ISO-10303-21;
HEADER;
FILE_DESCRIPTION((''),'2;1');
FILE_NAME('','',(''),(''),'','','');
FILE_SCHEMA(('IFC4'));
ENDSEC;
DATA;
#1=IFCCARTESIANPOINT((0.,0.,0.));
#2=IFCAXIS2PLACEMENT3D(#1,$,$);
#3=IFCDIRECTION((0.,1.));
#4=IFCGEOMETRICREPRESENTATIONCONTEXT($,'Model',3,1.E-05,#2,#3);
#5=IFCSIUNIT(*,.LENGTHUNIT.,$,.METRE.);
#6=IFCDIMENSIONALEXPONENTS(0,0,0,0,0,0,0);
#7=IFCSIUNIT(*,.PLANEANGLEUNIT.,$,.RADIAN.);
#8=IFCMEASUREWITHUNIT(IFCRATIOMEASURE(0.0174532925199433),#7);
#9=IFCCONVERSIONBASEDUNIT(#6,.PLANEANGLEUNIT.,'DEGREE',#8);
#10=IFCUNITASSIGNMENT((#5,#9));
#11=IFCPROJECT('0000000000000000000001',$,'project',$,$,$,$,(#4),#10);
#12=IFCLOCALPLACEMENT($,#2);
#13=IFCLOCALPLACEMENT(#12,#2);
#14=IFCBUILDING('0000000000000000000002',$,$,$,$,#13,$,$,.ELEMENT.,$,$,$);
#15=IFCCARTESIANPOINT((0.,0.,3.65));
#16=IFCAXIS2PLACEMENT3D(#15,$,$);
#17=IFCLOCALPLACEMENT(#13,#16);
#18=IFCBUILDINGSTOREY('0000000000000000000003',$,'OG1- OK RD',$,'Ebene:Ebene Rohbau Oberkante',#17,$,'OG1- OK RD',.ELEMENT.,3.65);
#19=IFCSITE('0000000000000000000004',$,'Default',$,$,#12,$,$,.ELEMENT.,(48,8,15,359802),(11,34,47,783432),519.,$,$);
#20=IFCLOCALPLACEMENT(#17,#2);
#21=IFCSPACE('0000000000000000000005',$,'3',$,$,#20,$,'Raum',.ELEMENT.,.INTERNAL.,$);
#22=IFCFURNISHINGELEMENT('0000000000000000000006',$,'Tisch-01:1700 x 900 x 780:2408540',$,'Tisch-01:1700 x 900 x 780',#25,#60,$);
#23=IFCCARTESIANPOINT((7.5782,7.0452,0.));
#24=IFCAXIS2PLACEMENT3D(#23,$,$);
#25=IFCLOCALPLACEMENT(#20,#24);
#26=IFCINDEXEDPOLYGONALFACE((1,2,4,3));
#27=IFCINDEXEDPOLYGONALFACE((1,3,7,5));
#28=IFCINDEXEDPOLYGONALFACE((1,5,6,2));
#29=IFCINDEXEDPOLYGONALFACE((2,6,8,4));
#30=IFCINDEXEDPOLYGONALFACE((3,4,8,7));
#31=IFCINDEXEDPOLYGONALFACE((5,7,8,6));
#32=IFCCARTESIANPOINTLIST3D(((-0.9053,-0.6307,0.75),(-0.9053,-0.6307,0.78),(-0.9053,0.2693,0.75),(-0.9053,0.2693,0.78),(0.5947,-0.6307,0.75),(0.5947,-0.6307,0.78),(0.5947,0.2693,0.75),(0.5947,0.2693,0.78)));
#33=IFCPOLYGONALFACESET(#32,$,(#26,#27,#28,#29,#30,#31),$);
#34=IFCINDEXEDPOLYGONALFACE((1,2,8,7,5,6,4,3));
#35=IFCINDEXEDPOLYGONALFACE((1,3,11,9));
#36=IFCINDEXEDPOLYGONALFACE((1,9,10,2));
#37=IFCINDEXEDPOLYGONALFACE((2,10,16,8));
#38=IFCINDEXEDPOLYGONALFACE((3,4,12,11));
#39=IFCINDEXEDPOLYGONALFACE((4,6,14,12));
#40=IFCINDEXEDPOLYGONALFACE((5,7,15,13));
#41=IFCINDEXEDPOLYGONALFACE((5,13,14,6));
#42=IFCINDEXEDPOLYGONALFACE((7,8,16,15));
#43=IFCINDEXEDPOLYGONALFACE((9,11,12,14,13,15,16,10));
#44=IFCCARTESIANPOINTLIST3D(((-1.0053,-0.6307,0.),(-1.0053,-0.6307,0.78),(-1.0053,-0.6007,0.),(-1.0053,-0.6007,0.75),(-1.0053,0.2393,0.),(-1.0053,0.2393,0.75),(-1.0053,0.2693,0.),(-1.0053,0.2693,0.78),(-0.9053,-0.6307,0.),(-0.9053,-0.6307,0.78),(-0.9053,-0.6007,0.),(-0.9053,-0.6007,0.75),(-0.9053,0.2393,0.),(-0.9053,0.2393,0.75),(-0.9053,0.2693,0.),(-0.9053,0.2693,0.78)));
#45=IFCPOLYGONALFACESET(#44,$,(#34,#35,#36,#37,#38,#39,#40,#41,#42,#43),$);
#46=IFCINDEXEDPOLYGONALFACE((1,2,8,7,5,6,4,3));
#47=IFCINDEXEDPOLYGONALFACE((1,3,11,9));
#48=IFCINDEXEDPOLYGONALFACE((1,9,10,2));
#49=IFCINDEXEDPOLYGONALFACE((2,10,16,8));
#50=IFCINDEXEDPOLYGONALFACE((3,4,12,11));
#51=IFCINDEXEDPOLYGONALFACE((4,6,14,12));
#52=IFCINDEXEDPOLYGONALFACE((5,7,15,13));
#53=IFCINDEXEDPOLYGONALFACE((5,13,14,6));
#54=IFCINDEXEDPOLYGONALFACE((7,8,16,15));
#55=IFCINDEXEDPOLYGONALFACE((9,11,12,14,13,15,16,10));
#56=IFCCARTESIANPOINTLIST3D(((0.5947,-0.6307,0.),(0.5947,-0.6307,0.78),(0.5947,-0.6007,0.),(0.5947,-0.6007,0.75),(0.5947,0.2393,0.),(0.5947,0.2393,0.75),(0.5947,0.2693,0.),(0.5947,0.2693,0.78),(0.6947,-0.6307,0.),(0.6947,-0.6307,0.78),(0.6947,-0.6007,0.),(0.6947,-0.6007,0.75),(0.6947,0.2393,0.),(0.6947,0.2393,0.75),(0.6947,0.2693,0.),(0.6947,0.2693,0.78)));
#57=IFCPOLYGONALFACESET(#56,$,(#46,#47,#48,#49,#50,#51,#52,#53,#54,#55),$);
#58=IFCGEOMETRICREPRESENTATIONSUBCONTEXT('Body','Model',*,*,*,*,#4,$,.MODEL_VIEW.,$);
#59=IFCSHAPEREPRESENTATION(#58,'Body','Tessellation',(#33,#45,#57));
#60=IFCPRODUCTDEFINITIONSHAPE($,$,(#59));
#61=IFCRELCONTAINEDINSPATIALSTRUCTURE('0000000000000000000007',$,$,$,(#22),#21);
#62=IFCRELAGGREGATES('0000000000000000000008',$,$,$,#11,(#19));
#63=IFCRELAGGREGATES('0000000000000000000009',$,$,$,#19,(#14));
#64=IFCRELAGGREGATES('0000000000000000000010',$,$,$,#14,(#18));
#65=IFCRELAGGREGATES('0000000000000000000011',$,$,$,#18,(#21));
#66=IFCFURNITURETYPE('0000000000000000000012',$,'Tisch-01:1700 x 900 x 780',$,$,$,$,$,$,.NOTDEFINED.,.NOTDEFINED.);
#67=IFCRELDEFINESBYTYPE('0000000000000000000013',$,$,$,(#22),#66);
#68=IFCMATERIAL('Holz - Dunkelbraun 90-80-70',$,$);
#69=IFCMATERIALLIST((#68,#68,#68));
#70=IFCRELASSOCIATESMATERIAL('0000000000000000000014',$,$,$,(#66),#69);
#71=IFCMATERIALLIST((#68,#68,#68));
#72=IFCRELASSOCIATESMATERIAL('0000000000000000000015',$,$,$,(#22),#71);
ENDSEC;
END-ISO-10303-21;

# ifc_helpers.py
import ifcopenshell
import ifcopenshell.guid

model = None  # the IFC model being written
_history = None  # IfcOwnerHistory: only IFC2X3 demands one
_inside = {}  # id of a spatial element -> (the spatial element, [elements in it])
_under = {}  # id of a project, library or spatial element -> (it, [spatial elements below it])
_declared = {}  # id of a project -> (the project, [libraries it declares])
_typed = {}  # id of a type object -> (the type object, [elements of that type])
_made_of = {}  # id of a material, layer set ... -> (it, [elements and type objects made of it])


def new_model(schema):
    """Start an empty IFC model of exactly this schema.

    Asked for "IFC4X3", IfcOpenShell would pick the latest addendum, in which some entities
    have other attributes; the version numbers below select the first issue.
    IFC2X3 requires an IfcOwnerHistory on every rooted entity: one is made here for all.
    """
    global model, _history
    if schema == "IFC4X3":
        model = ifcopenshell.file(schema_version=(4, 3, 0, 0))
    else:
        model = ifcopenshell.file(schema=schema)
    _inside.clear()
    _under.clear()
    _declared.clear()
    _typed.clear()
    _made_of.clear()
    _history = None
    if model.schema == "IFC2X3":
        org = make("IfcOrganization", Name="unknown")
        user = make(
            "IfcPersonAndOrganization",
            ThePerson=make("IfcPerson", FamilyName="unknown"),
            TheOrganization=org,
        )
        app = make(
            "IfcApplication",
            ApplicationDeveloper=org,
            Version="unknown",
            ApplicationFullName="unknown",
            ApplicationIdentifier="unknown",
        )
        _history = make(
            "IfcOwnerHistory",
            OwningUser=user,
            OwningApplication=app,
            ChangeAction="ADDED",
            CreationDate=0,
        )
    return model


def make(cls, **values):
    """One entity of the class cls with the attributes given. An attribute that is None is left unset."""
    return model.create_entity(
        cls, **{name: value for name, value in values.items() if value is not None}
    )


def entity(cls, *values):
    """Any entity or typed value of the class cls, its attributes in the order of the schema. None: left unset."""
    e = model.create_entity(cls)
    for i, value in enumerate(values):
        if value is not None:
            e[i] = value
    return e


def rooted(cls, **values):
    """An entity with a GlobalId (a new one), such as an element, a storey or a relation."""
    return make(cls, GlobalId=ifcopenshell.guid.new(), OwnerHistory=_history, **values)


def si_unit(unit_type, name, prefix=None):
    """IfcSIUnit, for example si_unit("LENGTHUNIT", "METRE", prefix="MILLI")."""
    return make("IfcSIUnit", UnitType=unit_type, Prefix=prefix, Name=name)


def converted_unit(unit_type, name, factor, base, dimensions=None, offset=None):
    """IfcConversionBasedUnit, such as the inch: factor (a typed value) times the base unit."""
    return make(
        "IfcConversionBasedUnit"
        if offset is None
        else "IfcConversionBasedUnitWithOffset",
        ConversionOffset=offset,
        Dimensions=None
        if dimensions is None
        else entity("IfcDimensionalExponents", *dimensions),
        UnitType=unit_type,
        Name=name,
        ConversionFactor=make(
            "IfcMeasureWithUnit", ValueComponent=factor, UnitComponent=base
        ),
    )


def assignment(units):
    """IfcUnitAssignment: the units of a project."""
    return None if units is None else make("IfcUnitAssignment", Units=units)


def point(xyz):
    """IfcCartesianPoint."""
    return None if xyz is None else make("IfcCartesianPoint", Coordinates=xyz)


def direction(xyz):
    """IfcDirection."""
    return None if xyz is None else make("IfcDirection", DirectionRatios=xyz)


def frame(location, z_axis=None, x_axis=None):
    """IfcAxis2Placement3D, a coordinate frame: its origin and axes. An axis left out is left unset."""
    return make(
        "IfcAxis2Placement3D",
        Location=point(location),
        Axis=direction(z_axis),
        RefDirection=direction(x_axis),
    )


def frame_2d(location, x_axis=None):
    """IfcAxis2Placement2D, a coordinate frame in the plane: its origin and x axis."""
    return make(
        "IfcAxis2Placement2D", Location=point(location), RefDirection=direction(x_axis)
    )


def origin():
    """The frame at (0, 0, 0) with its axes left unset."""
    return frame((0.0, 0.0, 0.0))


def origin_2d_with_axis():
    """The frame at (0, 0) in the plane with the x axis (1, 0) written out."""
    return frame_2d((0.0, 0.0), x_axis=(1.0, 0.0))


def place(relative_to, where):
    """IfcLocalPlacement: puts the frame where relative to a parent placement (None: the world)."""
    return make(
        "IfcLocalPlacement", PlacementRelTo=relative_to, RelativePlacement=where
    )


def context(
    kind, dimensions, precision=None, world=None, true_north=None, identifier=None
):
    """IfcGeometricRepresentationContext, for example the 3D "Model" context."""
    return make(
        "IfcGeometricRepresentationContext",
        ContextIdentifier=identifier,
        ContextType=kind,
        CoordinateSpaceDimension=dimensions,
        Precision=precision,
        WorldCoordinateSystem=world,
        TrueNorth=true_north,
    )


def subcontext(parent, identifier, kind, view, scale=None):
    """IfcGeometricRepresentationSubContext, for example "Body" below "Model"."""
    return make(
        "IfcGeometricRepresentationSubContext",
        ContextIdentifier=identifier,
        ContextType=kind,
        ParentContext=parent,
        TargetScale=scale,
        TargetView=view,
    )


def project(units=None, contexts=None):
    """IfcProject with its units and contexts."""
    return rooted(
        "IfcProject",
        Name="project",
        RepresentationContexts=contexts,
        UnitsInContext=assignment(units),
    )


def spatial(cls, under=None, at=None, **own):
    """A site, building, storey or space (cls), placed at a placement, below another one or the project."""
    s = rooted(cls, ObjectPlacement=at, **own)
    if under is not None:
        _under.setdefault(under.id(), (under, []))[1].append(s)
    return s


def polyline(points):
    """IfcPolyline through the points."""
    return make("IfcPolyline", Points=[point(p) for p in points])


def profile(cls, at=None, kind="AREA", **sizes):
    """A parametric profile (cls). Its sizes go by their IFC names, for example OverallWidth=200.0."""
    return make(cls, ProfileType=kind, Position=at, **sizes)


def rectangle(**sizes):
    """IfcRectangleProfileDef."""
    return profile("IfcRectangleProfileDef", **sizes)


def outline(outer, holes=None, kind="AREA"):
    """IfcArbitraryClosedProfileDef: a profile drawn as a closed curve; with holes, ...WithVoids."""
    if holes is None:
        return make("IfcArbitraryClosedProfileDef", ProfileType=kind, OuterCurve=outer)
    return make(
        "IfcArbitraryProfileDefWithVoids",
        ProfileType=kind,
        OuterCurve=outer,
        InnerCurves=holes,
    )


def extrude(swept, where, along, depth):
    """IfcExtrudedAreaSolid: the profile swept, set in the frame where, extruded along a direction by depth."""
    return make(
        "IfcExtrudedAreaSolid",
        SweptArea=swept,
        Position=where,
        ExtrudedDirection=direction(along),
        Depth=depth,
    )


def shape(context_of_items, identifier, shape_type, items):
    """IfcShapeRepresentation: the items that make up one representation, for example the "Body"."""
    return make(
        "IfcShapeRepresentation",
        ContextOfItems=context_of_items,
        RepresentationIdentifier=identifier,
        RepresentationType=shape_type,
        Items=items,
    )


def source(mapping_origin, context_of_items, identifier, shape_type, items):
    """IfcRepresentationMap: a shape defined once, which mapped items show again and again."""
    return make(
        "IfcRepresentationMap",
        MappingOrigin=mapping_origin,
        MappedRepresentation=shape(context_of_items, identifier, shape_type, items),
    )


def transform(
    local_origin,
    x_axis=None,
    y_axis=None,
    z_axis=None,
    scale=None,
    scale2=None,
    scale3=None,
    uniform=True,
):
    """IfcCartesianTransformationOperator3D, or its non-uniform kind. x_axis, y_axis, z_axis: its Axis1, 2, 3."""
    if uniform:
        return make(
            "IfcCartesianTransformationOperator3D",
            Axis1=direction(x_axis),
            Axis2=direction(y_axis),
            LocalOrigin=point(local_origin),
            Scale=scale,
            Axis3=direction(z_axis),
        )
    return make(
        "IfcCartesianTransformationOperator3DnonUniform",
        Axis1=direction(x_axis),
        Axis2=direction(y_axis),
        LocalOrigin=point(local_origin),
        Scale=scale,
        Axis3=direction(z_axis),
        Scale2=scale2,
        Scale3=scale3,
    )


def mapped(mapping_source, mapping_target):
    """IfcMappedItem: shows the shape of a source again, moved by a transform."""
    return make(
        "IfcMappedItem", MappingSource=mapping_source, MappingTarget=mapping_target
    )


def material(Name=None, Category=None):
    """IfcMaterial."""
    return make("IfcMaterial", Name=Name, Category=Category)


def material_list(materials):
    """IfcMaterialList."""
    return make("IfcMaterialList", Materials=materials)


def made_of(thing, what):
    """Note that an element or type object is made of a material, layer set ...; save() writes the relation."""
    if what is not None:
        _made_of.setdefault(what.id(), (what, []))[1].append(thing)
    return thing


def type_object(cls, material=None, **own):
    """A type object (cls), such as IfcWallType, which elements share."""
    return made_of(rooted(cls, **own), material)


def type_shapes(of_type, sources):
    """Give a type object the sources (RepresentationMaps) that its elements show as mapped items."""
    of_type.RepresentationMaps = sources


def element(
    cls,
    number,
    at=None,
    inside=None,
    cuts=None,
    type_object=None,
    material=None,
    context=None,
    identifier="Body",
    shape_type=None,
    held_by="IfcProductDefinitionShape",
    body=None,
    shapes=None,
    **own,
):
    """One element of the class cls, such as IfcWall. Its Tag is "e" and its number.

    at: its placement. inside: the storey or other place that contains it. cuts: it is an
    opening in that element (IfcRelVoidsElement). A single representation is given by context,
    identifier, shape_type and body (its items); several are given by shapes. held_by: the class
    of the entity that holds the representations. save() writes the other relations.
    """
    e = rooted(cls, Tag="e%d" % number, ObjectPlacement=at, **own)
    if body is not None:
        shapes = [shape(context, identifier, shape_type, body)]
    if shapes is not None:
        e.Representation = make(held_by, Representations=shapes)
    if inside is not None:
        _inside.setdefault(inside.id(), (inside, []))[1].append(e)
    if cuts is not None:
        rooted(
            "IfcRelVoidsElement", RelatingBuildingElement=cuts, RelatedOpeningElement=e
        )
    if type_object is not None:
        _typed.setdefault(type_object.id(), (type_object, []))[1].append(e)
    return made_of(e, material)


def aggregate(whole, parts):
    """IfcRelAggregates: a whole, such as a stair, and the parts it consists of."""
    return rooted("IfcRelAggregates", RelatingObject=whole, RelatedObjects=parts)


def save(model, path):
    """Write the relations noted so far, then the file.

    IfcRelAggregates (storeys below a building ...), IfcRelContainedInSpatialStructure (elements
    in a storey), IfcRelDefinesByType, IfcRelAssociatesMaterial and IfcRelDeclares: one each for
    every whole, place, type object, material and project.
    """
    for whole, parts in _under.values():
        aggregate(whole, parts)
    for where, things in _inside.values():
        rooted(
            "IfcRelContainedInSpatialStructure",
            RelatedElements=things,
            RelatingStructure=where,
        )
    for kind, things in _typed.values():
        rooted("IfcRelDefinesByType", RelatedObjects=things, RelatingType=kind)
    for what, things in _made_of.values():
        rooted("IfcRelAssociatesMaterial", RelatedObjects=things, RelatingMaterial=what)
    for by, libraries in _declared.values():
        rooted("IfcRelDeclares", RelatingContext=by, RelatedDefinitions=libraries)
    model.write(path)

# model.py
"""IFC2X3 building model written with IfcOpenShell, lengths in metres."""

from ifc_helpers import new_model, entity, si_unit, converted_unit, direction, frame, origin, origin_2d_with_axis, place, context, subcontext, project, spatial, polyline, rectangle, outline, extrude, source, transform, mapped, material, material_list, type_object, type_shapes, element, save


model = new_model("IFC2X3")

# Units and contexts
model_context = context("Model", 3, precision=1e-05, world=origin(), true_north=direction((0.0, 1.0)))
body_context = subcontext(model_context, "Body", "Model", "MODEL_VIEW")
ifc_project = project(units=[si_unit("LENGTHUNIT", "METRE"), converted_unit("PLANEANGLEUNIT", "DEGREE", entity("IfcRatioMeasure", 0.0174532925199433), si_unit("PLANEANGLEUNIT", "RADIAN"), dimensions=[0, 0, 0, 0, 0, 0, 0])], contexts=[model_context])

# Site, building, storey
site_placement = place(None, origin())
site = spatial("IfcSite", under=ifc_project, at=site_placement, Name="Default", CompositionType="ELEMENT", RefLatitude=(48, 8, 15, 359802), RefLongitude=(11, 34, 47, 783432), RefElevation=519.0)
building_placement = place(site_placement, origin())
building = spatial("IfcBuilding", under=site, at=building_placement, CompositionType="ELEMENT")
storey_placement = place(building_placement, frame((0.0, 0.0, 3.65)))
storey = spatial("IfcBuildingStorey", under=building, at=storey_placement, Name="OG1- OK RD", ObjectType="Ebene:Ebene Rohbau Oberkante", LongName="OG1- OK RD", CompositionType="ELEMENT", Elevation=3.65)

# Shared definitions
space_placement = place(storey_placement, origin())
space = spatial("IfcSpace", under=storey, at=space_placement, Name="3", LongName="Raum", CompositionType="ELEMENT", InteriorOrExteriorSpace="INTERNAL")

# Furnishing element
ifc_material_1 = material(Name="Holz - Dunkelbraun 90-80-70")
ifc_material_list_1 = material_list([ifc_material_1, ifc_material_1, ifc_material_1])
ifc_material_list_2 = material_list([ifc_material_1, ifc_material_1, ifc_material_1])
furniture_type_1 = type_object("IfcFurnitureType", Name="Tisch-01:1700 x 900 x 780", material=ifc_material_list_2)
shared_shape_1 = source(origin(), body_context, "Body", "SweptSolid", [
    extrude(rectangle(XDim=1.5, YDim=0.9, at=origin_2d_with_axis()), frame((-0.1553, -0.1807, 0.75), z_axis=(0.0, 0.0, 1.0), x_axis=(-1.0, 0.0, 0.0)), (0.0, 0.0, 1.0), 0.03),
    extrude(outline(polyline([(-0.3975, -0.45), (0.3825, -0.45), (0.3825, -0.42), (-0.3675, -0.42), (-0.3675, 0.42), (0.3825, 0.42), (0.3825, 0.45), (-0.3975, 0.45), (-0.3975, -0.45)])), frame((-1.0053, -0.1807, 0.3825), z_axis=(1.0, 0.0, 0.0), x_axis=(0.0, 0.0, -1.0)), (0.0, 0.0, 1.0), 0.1),
    extrude(outline(polyline([(-0.3975, -0.45), (0.3825, -0.45), (0.3825, -0.42), (-0.3675, -0.42), (-0.3675, 0.42), (0.3825, 0.42), (0.3825, 0.45), (-0.3975, 0.45), (-0.3975, -0.45)])), frame((0.5947, -0.1807, 0.3825), z_axis=(1.0, 0.0, 0.0), x_axis=(0.0, 0.0, -1.0)), (0.0, 0.0, 1.0), 0.1),
])
type_shapes(furniture_type_1, [shared_shape_1])
furnishing_1_placement = place(space_placement, frame((7.5782, 7.0452, 0.0)))
element("IfcFurnishingElement", 1, at=furnishing_1_placement, inside=space, type_object=furniture_type_1, material=ifc_material_list_1, Name="Tisch-01:1700 x 900 x 780:2408540", ObjectType="Tisch-01:1700 x 900 x 780", context=body_context, shape_type="MappedRepresentation", body=[
    mapped(shared_shape_1, transform((0.0, 0.0, 0.0), scale=1.0)),
])

save(model, "model.ifc")
